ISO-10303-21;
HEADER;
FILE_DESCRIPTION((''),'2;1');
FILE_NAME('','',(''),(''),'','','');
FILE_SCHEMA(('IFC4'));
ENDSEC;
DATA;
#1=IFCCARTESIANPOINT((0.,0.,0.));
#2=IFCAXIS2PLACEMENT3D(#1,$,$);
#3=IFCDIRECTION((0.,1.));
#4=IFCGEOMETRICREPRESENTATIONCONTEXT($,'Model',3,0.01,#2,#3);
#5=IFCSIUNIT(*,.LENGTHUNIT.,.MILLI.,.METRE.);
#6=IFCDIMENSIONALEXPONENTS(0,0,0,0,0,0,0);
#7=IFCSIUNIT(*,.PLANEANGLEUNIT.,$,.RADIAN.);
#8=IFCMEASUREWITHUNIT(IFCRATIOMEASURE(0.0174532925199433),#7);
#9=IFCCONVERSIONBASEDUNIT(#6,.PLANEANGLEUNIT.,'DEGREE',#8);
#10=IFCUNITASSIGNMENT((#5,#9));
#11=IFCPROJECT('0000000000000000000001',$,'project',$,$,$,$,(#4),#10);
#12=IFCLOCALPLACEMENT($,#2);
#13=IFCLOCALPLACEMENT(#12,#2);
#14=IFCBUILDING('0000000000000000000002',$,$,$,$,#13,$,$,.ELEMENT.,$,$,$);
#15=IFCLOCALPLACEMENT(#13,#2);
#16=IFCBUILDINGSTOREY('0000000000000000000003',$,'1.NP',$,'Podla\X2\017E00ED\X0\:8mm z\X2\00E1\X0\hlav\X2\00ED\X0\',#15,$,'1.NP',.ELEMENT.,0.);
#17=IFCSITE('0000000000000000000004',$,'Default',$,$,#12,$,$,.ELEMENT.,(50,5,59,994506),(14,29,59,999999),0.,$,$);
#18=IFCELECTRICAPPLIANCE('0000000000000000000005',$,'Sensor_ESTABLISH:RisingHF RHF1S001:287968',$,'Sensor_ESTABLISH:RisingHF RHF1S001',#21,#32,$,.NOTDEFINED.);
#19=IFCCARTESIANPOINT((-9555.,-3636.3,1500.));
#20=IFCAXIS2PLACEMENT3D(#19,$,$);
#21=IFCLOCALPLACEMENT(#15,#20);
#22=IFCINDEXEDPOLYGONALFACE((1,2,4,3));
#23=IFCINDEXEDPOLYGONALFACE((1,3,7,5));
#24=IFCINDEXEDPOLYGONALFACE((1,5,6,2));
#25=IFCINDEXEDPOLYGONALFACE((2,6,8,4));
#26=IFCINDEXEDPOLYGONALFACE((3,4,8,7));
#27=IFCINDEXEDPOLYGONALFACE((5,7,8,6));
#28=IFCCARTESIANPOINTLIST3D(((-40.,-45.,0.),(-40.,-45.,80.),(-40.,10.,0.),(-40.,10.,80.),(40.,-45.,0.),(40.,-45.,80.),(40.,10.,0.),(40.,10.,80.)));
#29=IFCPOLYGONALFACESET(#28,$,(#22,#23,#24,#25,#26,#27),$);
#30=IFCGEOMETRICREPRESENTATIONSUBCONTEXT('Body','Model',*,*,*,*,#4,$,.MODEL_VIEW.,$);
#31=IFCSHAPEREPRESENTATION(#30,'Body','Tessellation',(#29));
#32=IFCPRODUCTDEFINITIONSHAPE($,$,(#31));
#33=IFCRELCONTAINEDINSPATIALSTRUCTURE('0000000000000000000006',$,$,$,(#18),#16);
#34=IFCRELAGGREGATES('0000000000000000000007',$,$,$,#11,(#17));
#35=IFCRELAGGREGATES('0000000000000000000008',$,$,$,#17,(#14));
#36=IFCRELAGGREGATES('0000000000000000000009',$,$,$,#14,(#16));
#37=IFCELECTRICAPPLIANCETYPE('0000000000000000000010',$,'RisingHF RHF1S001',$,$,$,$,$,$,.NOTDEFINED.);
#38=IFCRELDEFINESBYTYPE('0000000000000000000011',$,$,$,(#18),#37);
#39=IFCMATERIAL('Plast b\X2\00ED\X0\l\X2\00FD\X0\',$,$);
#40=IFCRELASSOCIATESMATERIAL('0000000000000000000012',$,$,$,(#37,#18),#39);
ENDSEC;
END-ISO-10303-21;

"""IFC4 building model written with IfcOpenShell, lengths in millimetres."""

from ifc_helpers import new_model, entity, si_unit, converted_unit, direction, frame, frame_2d, origin, place, context, subcontext, project, spatial, rectangle, extrude, source, transform, mapped, material, type_object, type_shapes, element, save


model = new_model("IFC4")

# Units and contexts
model_context = context("Model", 3, precision=0.01, world=origin(), true_north=direction((0.0, 1.0)))
body_context = subcontext(model_context, "Body", "Model", "MODEL_VIEW")
ifc_project = project(units=[si_unit("LENGTHUNIT", "METRE", prefix="MILLI"), converted_unit("PLANEANGLEUNIT", "DEGREE", entity("IfcRatioMeasure", 0.0174532925199433), si_unit("PLANEANGLEUNIT", "RADIAN"), dimensions=[0, 0, 0, 0, 0, 0, 0])], contexts=[model_context])

# Site, building, storey
site_placement = place(None, origin())
site = spatial("IfcSite", under=ifc_project, at=site_placement, Name="Default", CompositionType="ELEMENT", RefLatitude=(50, 5, 59, 994506), RefLongitude=(14, 29, 59, 999999), RefElevation=0.0)
building_placement = place(site_placement, origin())
building = spatial("IfcBuilding", under=site, at=building_placement, CompositionType="ELEMENT")
storey_placement = place(building_placement, origin())
storey = spatial("IfcBuildingStorey", under=building, at=storey_placement, Name="1.NP", ObjectType="Podlaží:8mm záhlaví", LongName="1.NP", CompositionType="ELEMENT", Elevation=0.0)

# Electric appliance
ifc_material_1 = material(Name="Plast bílý")
electric_appliance_type = type_object("IfcElectricApplianceType", Name="RisingHF RHF1S001", PredefinedType="NOTDEFINED", material=ifc_material_1)
shared_shape_1 = source(origin(), body_context, "Body", "SweptSolid", [
    extrude(rectangle(XDim=80.0, YDim=55.0, at=frame_2d((0.0, 0.0), x_axis=(1.0, 0.0))), frame((0.0, -17.5, 0.0), z_axis=(0.0, 0.0, 1.0), x_axis=(-1.0, 0.0, 0.0)), (0.0, 0.0, 1.0), 80.0),
])
type_shapes(electric_appliance_type, [shared_shape_1])
electric_appliance_placement = place(storey_placement, frame((-9555.0, -3636.3, 1500.0)))
element("IfcElectricAppliance", 1, at=electric_appliance_placement, inside=storey, type_object=electric_appliance_type, material=ifc_material_1, Name="Sensor_ESTABLISH:RisingHF RHF1S001:287968", ObjectType="Sensor_ESTABLISH:RisingHF RHF1S001", PredefinedType="NOTDEFINED", context=body_context, shape_type="MappedRepresentation", body=[
    mapped(shared_shape_1, transform((0.0, 0.0, 0.0), scale=1.0)),
])

save(model, "model.ifc")
